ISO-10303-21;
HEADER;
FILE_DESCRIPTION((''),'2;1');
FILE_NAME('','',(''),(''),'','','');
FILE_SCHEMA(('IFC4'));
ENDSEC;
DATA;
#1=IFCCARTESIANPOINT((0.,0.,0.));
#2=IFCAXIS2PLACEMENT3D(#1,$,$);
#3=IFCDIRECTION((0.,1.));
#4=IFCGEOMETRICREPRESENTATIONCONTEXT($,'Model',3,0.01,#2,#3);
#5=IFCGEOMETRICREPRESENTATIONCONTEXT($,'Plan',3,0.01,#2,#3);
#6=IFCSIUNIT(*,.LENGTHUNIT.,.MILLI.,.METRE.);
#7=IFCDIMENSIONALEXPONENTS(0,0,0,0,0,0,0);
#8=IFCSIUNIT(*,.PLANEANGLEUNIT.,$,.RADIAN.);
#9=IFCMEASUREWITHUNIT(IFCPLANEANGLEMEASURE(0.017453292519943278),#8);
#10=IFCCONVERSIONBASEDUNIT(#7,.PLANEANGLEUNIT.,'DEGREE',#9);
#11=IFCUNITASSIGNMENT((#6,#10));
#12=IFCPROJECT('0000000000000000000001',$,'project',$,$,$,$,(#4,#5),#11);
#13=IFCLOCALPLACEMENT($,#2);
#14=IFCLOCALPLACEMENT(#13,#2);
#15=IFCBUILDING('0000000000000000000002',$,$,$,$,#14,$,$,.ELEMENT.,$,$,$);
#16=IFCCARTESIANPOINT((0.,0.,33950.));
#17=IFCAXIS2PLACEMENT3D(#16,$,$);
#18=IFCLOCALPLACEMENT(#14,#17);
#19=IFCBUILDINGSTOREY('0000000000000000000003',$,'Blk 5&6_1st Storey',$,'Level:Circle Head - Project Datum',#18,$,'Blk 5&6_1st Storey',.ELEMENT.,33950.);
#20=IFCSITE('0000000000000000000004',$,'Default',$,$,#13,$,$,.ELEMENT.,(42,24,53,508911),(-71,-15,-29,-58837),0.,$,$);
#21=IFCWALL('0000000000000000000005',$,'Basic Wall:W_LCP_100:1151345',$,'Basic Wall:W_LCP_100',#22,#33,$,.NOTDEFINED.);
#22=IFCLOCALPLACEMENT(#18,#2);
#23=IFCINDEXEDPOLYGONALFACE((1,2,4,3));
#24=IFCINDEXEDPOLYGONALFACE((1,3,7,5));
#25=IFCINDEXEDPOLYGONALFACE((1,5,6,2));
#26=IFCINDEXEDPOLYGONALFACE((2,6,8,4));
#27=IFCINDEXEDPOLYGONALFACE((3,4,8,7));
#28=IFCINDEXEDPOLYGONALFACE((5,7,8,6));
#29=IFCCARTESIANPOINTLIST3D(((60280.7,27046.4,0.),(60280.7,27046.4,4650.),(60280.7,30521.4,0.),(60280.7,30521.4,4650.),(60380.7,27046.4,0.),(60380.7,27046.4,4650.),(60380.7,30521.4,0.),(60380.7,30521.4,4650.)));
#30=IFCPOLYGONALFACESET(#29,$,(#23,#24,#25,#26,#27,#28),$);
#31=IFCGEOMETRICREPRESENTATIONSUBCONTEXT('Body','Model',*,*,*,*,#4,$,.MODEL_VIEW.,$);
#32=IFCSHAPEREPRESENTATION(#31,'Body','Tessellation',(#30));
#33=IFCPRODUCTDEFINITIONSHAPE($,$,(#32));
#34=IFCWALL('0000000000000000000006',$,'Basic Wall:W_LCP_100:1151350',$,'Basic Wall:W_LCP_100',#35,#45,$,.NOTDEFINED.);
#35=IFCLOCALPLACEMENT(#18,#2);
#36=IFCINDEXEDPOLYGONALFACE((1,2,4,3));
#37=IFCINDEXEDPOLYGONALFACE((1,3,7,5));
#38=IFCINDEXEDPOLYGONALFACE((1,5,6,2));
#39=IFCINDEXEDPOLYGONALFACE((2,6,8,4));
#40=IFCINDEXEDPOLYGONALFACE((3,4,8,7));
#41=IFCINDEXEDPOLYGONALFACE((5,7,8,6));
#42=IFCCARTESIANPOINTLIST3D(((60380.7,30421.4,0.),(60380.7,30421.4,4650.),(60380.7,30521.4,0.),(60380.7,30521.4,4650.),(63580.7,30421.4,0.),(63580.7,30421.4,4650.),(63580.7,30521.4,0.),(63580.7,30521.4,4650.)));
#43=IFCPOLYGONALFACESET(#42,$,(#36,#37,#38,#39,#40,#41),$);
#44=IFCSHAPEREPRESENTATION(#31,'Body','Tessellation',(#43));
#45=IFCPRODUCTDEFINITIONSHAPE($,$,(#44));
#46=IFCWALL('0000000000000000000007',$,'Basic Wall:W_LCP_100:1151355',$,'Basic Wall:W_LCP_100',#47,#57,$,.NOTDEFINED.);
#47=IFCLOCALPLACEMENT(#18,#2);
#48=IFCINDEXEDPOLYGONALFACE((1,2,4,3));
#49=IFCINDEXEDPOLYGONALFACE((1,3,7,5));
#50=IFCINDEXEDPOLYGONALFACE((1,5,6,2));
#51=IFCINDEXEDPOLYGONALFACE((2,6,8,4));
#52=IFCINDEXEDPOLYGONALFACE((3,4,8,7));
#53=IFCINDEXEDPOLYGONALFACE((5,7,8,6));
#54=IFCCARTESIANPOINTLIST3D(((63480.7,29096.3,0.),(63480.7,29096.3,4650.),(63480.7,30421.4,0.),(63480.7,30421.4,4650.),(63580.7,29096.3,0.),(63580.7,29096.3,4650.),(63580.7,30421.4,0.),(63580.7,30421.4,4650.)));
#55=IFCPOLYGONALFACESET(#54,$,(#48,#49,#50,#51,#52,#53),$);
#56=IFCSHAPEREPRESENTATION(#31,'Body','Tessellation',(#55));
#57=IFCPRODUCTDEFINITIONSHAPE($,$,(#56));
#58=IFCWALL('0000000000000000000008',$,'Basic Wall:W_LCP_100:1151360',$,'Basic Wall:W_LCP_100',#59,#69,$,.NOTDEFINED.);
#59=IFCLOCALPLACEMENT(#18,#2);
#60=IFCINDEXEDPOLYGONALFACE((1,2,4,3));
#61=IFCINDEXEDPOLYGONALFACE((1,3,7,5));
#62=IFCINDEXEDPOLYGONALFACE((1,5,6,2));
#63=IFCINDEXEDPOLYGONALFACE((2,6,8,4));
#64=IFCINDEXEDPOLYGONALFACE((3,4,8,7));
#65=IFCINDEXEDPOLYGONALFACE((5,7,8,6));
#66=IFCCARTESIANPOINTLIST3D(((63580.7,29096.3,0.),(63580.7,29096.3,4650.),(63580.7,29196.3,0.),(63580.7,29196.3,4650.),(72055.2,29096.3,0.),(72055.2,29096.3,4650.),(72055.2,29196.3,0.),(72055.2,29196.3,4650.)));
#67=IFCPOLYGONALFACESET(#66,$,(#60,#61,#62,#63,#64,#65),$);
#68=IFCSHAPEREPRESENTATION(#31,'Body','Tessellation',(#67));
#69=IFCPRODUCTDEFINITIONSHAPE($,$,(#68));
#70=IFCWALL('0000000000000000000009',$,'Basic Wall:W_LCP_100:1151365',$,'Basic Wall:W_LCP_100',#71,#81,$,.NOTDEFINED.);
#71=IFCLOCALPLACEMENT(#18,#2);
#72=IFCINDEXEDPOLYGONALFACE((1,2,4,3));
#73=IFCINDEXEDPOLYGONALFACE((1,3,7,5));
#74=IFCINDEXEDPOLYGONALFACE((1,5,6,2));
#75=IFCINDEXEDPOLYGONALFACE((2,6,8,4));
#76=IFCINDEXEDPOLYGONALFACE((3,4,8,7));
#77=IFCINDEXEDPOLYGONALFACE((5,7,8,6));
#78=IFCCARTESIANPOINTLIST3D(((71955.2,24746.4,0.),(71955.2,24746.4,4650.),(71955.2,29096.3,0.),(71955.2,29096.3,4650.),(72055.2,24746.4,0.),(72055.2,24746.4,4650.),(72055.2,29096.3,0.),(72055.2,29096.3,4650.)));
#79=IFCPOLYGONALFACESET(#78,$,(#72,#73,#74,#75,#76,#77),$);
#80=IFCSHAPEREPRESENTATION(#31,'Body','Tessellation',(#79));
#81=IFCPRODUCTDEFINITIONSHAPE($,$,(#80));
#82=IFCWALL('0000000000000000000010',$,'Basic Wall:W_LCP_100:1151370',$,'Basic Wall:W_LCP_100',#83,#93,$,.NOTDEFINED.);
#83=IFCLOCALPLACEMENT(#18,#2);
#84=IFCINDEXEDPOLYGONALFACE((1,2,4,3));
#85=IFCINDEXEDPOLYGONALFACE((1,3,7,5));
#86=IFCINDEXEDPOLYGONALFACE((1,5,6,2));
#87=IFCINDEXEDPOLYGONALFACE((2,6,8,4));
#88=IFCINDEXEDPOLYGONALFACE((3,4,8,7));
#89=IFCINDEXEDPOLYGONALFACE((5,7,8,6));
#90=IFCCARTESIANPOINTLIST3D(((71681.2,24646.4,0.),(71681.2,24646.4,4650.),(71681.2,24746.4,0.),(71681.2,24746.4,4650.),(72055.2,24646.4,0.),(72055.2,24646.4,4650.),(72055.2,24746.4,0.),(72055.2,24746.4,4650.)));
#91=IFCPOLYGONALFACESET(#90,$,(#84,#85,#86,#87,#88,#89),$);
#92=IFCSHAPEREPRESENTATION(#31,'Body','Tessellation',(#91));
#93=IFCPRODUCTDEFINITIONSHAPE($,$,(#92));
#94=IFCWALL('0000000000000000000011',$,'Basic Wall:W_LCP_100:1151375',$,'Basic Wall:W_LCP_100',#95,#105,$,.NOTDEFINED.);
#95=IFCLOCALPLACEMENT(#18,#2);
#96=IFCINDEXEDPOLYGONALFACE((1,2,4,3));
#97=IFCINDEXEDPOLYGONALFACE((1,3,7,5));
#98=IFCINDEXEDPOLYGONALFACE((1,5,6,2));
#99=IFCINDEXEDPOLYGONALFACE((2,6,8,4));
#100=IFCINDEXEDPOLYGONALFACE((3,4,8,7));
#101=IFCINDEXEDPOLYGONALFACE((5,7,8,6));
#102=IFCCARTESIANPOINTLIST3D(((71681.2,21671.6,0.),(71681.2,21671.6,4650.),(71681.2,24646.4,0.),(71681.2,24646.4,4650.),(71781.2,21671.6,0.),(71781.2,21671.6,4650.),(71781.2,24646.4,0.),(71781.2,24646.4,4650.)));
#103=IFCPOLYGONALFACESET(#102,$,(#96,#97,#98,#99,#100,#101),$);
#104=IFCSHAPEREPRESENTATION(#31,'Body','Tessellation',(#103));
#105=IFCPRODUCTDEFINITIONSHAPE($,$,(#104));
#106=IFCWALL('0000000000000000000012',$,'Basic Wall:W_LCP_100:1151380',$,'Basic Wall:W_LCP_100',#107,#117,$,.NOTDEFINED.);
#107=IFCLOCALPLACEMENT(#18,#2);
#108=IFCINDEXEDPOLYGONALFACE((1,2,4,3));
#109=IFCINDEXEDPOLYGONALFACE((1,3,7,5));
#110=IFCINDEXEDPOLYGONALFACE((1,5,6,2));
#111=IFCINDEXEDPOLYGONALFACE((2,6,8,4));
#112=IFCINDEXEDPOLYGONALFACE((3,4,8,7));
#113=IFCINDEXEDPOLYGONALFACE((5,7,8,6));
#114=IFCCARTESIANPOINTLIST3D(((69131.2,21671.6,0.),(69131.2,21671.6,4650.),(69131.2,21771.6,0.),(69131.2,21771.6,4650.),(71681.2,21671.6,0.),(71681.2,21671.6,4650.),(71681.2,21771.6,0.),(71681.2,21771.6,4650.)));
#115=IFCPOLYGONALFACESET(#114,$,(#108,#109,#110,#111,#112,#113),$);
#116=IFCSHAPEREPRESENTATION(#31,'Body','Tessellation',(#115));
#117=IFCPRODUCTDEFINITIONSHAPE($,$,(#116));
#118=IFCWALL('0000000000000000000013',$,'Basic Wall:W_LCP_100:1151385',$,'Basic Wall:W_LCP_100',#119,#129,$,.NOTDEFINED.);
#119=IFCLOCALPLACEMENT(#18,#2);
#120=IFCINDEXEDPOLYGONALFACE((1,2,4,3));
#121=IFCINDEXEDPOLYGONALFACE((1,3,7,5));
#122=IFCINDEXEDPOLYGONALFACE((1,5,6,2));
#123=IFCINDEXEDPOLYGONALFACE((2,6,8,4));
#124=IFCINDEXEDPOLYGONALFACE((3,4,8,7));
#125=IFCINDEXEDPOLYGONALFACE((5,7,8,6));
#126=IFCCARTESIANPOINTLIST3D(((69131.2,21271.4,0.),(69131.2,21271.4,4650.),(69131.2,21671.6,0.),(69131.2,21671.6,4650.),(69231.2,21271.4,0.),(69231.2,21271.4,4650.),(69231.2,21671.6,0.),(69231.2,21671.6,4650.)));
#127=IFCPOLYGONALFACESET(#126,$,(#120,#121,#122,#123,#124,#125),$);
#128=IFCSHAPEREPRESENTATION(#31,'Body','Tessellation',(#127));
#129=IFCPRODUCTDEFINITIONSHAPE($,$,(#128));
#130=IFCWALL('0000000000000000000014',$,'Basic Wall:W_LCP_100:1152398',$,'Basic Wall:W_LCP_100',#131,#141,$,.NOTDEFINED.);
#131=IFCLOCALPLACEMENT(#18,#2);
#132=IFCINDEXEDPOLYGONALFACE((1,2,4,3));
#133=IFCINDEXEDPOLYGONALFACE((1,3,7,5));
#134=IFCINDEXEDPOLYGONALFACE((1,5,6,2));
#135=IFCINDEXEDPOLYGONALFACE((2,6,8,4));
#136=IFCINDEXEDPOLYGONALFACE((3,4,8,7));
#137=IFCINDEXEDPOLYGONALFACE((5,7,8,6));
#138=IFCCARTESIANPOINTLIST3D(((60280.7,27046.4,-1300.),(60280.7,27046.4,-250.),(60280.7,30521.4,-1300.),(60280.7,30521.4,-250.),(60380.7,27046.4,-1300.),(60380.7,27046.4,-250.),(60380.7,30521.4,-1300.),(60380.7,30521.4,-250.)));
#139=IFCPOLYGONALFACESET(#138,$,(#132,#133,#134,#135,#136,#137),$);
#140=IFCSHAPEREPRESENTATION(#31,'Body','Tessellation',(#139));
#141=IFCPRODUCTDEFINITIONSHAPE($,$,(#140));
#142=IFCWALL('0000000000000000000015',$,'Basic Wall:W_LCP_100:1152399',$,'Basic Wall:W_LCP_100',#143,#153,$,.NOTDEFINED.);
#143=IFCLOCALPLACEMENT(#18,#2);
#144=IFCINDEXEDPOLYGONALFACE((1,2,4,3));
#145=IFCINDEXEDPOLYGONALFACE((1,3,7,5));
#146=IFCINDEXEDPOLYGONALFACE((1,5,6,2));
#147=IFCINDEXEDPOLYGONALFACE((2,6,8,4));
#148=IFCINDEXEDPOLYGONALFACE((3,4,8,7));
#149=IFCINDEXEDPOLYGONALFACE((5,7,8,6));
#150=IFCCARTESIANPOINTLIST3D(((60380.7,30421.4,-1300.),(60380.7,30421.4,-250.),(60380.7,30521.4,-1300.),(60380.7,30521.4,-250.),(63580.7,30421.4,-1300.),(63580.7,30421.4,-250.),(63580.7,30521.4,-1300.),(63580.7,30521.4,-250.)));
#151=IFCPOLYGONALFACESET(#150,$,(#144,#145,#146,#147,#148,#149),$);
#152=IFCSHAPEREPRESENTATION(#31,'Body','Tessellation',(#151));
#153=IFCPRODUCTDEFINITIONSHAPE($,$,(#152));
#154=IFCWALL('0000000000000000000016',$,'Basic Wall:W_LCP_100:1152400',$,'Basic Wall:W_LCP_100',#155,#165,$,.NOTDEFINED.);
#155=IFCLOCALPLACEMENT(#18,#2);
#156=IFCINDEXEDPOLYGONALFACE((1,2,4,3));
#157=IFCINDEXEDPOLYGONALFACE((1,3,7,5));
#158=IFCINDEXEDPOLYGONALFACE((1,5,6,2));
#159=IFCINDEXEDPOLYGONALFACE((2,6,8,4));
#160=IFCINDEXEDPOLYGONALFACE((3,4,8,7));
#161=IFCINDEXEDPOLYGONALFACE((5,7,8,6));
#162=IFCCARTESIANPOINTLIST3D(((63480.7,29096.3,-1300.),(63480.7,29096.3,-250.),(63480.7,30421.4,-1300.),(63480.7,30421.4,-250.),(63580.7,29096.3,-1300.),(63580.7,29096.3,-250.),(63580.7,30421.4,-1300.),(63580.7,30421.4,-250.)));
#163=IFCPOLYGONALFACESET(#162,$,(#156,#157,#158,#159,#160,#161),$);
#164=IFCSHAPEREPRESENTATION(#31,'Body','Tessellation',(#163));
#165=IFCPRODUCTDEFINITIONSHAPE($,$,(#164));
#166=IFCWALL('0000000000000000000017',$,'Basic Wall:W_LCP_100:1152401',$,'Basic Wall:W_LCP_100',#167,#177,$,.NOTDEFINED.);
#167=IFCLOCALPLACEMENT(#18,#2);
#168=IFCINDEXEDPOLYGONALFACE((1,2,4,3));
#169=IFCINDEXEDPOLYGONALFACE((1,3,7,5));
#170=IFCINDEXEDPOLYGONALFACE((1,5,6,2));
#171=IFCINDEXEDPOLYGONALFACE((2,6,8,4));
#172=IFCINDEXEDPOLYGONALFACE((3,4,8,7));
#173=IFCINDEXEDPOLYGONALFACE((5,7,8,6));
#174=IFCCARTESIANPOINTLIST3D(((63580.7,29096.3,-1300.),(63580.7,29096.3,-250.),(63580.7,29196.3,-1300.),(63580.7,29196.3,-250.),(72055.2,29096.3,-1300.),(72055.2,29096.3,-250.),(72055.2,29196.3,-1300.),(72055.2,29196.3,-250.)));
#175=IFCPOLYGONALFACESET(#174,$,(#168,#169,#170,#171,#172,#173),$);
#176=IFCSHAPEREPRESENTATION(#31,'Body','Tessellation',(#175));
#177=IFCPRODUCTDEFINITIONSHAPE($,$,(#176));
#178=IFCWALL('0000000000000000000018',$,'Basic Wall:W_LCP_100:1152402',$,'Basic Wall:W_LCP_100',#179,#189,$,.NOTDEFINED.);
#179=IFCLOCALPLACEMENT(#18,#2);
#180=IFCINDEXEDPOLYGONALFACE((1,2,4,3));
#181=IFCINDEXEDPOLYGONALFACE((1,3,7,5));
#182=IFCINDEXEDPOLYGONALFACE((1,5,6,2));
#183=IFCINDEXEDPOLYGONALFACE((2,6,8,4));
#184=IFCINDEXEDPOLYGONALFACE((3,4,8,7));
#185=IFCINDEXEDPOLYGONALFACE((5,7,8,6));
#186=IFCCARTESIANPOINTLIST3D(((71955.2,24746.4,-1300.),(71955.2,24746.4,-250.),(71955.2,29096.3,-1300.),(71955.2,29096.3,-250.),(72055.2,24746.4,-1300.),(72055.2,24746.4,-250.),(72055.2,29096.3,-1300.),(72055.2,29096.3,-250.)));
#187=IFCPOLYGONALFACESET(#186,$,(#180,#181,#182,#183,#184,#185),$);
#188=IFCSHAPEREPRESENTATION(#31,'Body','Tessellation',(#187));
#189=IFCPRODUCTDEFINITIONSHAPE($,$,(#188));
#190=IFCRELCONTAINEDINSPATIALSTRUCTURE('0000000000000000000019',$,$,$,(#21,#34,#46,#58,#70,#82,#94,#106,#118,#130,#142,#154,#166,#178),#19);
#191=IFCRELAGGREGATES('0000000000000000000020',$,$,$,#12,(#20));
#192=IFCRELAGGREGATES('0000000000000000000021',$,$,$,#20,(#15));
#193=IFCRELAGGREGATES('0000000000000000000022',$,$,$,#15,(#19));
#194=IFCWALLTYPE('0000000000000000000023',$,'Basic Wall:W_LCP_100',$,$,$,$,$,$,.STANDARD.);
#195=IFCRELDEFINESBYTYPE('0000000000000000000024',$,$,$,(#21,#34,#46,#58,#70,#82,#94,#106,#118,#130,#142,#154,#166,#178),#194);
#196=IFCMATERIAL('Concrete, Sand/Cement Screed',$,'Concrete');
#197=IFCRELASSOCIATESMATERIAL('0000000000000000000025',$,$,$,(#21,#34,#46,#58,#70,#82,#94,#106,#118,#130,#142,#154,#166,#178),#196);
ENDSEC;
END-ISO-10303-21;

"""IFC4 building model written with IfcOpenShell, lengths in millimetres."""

from ifc_helpers import new_model, entity, si_unit, converted_unit, direction, frame, origin, place, context, subcontext, project, spatial, indexed_curve, outline, extrude, material, type_object, element, save


model = new_model("IFC4")

# Units and contexts
model_context = context("Model", 3, precision=0.01, world=origin(), true_north=direction((0.0, 1.0)))
plan_context = context("Plan", 3, precision=0.01, world=origin(), true_north=direction((0.0, 1.0)))
body_context = subcontext(model_context, "Body", "Model", "MODEL_VIEW")
ifc_project = project(units=[si_unit("LENGTHUNIT", "METRE", prefix="MILLI"), converted_unit("PLANEANGLEUNIT", "DEGREE", entity("IfcPlaneAngleMeasure", 0.017453292519943278), si_unit("PLANEANGLEUNIT", "RADIAN"), dimensions=[0, 0, 0, 0, 0, 0, 0])], contexts=[model_context, plan_context])

# Site, building, storey
site_placement = place(None, origin())
site = spatial("IfcSite", under=ifc_project, at=site_placement, Name="Default", CompositionType="ELEMENT", RefLatitude=(42, 24, 53, 508911), RefLongitude=(-71, -15, -29, -58837), RefElevation=0.0)
building_placement = place(site_placement, origin())
building = spatial("IfcBuilding", under=site, at=building_placement, CompositionType="ELEMENT")
storey_placement = place(building_placement, frame((0.0, 0.0, 33950.0)))
storey = spatial("IfcBuildingStorey", under=building, at=storey_placement, Name="Blk 5&6_1st Storey", ObjectType="Level:Circle Head - Project Datum", LongName="Blk 5&6_1st Storey", CompositionType="ELEMENT", Elevation=33950.0)

# Walls
ifc_material_1 = material(Name="Concrete, Sand/Cement Screed", Category="Concrete")
wall_type_1 = type_object("IfcWallType", Name="Basic Wall:W_LCP_100", PredefinedType="STANDARD")
wall_1_placement = place(storey_placement, frame((60330.7, 27046.4, 0.0), z_axis=(0.0, 0.0, 1.0), x_axis=(0.0, 1.0, 0.0)))
element("IfcWall", 1, at=wall_1_placement, inside=storey, type_object=wall_type_1, material=ifc_material_1, Name="Basic Wall:W_LCP_100:1151345", ObjectType="Basic Wall:W_LCP_100", PredefinedType="NOTDEFINED", context=body_context, shape_type="SweptSolid", body=[
    extrude(outline(indexed_curve([(3475.0, 50.0), (0.0, 50.0), (0.0, -50.0), (3475.0, -50.0), (3475.0, 50.0)], self_intersect=False)), origin(), (0.0, 0.0, 1.0), 4650.0),
])
wall_2_placement = place(storey_placement, frame((60380.7, 30471.4, 0.0)))
element("IfcWall", 2, at=wall_2_placement, inside=storey, type_object=wall_type_1, material=ifc_material_1, Name="Basic Wall:W_LCP_100:1151350", ObjectType="Basic Wall:W_LCP_100", PredefinedType="NOTDEFINED", context=body_context, shape_type="SweptSolid", body=[
    extrude(outline(indexed_curve([(3200.0, 50.0), (0.0, 50.0), (0.0, -50.0), (3200.0, -50.0), (3200.0, 50.0)], self_intersect=False)), origin(), (0.0, 0.0, 1.0), 4650.0),
])
wall_3_placement = place(storey_placement, frame((63530.7, 30421.4, 0.0), z_axis=(0.0, 0.0, 1.0), x_axis=(0.0, -1.0, 0.0)))
element("IfcWall", 3, at=wall_3_placement, inside=storey, type_object=wall_type_1, material=ifc_material_1, Name="Basic Wall:W_LCP_100:1151355", ObjectType="Basic Wall:W_LCP_100", PredefinedType="NOTDEFINED", context=body_context, shape_type="SweptSolid", body=[
    extrude(outline(indexed_curve([(1325.1, 50.0), (0.0, 50.0), (0.0, -50.0), (1325.1, -50.0), (1325.1, 50.0)], self_intersect=False)), origin(), (0.0, 0.0, 1.0), 4650.0),
])
wall_4_placement = place(storey_placement, frame((63580.7, 29146.3, 0.0)))
element("IfcWall", 4, at=wall_4_placement, inside=storey, type_object=wall_type_1, material=ifc_material_1, Name="Basic Wall:W_LCP_100:1151360", ObjectType="Basic Wall:W_LCP_100", PredefinedType="NOTDEFINED", context=body_context, shape_type="SweptSolid", body=[
    extrude(outline(indexed_curve([(8474.5, 50.0), (0.0, 50.0), (0.0, -50.0), (8474.5, -50.0), (8474.5, 50.0)], self_intersect=False)), origin(), (0.0, 0.0, 1.0), 4650.0),
])
wall_5_placement = place(storey_placement, frame((72005.2, 29096.3, 0.0), z_axis=(0.0, 0.0, 1.0), x_axis=(0.0, -1.0, 0.0)))
element("IfcWall", 5, at=wall_5_placement, inside=storey, type_object=wall_type_1, material=ifc_material_1, Name="Basic Wall:W_LCP_100:1151365", ObjectType="Basic Wall:W_LCP_100", PredefinedType="NOTDEFINED", context=body_context, shape_type="SweptSolid", body=[
    extrude(outline(indexed_curve([(4349.9, 50.0), (0.0, 50.0), (0.0, -50.0), (4349.9, -50.0), (4349.9, 50.0)], self_intersect=False)), origin(), (0.0, 0.0, 1.0), 4650.0),
])
wall_6_placement = place(storey_placement, frame((72055.2, 24696.4, 0.0), z_axis=(0.0, 0.0, 1.0), x_axis=(-1.0, 0.0, 0.0)))
element("IfcWall", 6, at=wall_6_placement, inside=storey, type_object=wall_type_1, material=ifc_material_1, Name="Basic Wall:W_LCP_100:1151370", ObjectType="Basic Wall:W_LCP_100", PredefinedType="NOTDEFINED", context=body_context, shape_type="SweptSolid", body=[
    extrude(outline(indexed_curve([(373.9, 50.0), (0.0, 50.0), (0.0, -50.0), (373.9, -50.0), (373.9, 50.0)], self_intersect=False)), origin(), (0.0, 0.0, 1.0), 4650.0),
])
wall_7_placement = place(storey_placement, frame((71731.2, 24646.4, 0.0), z_axis=(0.0, 0.0, 1.0), x_axis=(0.0, -1.0, 0.0)))
element("IfcWall", 7, at=wall_7_placement, inside=storey, type_object=wall_type_1, material=ifc_material_1, Name="Basic Wall:W_LCP_100:1151375", ObjectType="Basic Wall:W_LCP_100", PredefinedType="NOTDEFINED", context=body_context, shape_type="SweptSolid", body=[
    extrude(outline(indexed_curve([(2974.8, 50.0), (0.0, 50.0), (0.0, -50.0), (2974.8, -50.0), (2974.8, 50.0)], self_intersect=False)), origin(), (0.0, 0.0, 1.0), 4650.0),
])
wall_8_placement = place(storey_placement, frame((71681.2, 21721.6, 0.0), z_axis=(0.0, 0.0, 1.0), x_axis=(-1.0, 0.0, 0.0)))
element("IfcWall", 8, at=wall_8_placement, inside=storey, type_object=wall_type_1, material=ifc_material_1, Name="Basic Wall:W_LCP_100:1151380", ObjectType="Basic Wall:W_LCP_100", PredefinedType="NOTDEFINED", context=body_context, shape_type="SweptSolid", body=[
    extrude(outline(indexed_curve([(2550.0, 50.0), (0.0, 50.0), (0.0, -50.0), (2550.0, -50.0), (2550.0, 50.0)], self_intersect=False)), origin(), (0.0, 0.0, 1.0), 4650.0),
])
wall_9_placement = place(storey_placement, frame((69181.2, 21671.6, 0.0), z_axis=(0.0, 0.0, 1.0), x_axis=(0.0, -1.0, 0.0)))
element("IfcWall", 9, at=wall_9_placement, inside=storey, type_object=wall_type_1, material=ifc_material_1, Name="Basic Wall:W_LCP_100:1151385", ObjectType="Basic Wall:W_LCP_100", PredefinedType="NOTDEFINED", context=body_context, shape_type="SweptSolid", body=[
    extrude(outline(indexed_curve([(400.2, 50.0), (0.0, 50.0), (0.0, -50.0), (400.2, -50.0), (400.2, 50.0)], self_intersect=False)), origin(), (0.0, 0.0, 1.0), 4650.0),
])
wall_10_placement = place(storey_placement, frame((60330.7, 27046.4, -1300.0), z_axis=(0.0, 0.0, 1.0), x_axis=(0.0, 1.0, 0.0)))
element("IfcWall", 10, at=wall_10_placement, inside=storey, type_object=wall_type_1, material=ifc_material_1, Name="Basic Wall:W_LCP_100:1152398", ObjectType="Basic Wall:W_LCP_100", PredefinedType="NOTDEFINED", context=body_context, shape_type="SweptSolid", body=[
    extrude(outline(indexed_curve([(3475.0, 50.0), (0.0, 50.0), (0.0, -50.0), (3475.0, -50.0), (3475.0, 50.0)], self_intersect=False)), origin(), (0.0, 0.0, 1.0), 1050.0),
])
wall_11_placement = place(storey_placement, frame((60380.7, 30471.4, -1300.0)))
element("IfcWall", 11, at=wall_11_placement, inside=storey, type_object=wall_type_1, material=ifc_material_1, Name="Basic Wall:W_LCP_100:1152399", ObjectType="Basic Wall:W_LCP_100", PredefinedType="NOTDEFINED", context=body_context, shape_type="SweptSolid", body=[
    extrude(outline(indexed_curve([(3200.0, 50.0), (0.0, 50.0), (0.0, -50.0), (3200.0, -50.0), (3200.0, 50.0)], self_intersect=False)), origin(), (0.0, 0.0, 1.0), 1050.0),
])
wall_12_placement = place(storey_placement, frame((63530.7, 30421.4, -1300.0), z_axis=(0.0, 0.0, 1.0), x_axis=(0.0, -1.0, 0.0)))
element("IfcWall", 12, at=wall_12_placement, inside=storey, type_object=wall_type_1, material=ifc_material_1, Name="Basic Wall:W_LCP_100:1152400", ObjectType="Basic Wall:W_LCP_100", PredefinedType="NOTDEFINED", context=body_context, shape_type="SweptSolid", body=[
    extrude(outline(indexed_curve([(1325.1, 50.0), (0.0, 50.0), (0.0, -50.0), (1325.1, -50.0), (1325.1, 50.0)], self_intersect=False)), origin(), (0.0, 0.0, 1.0), 1050.0),
])
wall_13_placement = place(storey_placement, frame((63580.7, 29146.3, -1300.0)))
element("IfcWall", 13, at=wall_13_placement, inside=storey, type_object=wall_type_1, material=ifc_material_1, Name="Basic Wall:W_LCP_100:1152401", ObjectType="Basic Wall:W_LCP_100", PredefinedType="NOTDEFINED", context=body_context, shape_type="SweptSolid", body=[
    extrude(outline(indexed_curve([(8474.5, 50.0), (0.0, 50.0), (0.0, -50.0), (8474.5, -50.0), (8474.5, 50.0)], self_intersect=False)), origin(), (0.0, 0.0, 1.0), 1050.0),
])
wall_14_placement = place(storey_placement, frame((72005.2, 29096.3, -1300.0), z_axis=(0.0, 0.0, 1.0), x_axis=(0.0, -1.0, 0.0)))
element("IfcWall", 14, at=wall_14_placement, inside=storey, type_object=wall_type_1, material=ifc_material_1, Name="Basic Wall:W_LCP_100:1152402", ObjectType="Basic Wall:W_LCP_100", PredefinedType="NOTDEFINED", context=body_context, shape_type="SweptSolid", body=[
    extrude(outline(indexed_curve([(4349.9, 50.0), (0.0, 50.0), (0.0, -50.0), (4349.9, -50.0), (4349.9, 50.0)], self_intersect=False)), origin(), (0.0, 0.0, 1.0), 1050.0),
])

save(model, "model.ifc")
